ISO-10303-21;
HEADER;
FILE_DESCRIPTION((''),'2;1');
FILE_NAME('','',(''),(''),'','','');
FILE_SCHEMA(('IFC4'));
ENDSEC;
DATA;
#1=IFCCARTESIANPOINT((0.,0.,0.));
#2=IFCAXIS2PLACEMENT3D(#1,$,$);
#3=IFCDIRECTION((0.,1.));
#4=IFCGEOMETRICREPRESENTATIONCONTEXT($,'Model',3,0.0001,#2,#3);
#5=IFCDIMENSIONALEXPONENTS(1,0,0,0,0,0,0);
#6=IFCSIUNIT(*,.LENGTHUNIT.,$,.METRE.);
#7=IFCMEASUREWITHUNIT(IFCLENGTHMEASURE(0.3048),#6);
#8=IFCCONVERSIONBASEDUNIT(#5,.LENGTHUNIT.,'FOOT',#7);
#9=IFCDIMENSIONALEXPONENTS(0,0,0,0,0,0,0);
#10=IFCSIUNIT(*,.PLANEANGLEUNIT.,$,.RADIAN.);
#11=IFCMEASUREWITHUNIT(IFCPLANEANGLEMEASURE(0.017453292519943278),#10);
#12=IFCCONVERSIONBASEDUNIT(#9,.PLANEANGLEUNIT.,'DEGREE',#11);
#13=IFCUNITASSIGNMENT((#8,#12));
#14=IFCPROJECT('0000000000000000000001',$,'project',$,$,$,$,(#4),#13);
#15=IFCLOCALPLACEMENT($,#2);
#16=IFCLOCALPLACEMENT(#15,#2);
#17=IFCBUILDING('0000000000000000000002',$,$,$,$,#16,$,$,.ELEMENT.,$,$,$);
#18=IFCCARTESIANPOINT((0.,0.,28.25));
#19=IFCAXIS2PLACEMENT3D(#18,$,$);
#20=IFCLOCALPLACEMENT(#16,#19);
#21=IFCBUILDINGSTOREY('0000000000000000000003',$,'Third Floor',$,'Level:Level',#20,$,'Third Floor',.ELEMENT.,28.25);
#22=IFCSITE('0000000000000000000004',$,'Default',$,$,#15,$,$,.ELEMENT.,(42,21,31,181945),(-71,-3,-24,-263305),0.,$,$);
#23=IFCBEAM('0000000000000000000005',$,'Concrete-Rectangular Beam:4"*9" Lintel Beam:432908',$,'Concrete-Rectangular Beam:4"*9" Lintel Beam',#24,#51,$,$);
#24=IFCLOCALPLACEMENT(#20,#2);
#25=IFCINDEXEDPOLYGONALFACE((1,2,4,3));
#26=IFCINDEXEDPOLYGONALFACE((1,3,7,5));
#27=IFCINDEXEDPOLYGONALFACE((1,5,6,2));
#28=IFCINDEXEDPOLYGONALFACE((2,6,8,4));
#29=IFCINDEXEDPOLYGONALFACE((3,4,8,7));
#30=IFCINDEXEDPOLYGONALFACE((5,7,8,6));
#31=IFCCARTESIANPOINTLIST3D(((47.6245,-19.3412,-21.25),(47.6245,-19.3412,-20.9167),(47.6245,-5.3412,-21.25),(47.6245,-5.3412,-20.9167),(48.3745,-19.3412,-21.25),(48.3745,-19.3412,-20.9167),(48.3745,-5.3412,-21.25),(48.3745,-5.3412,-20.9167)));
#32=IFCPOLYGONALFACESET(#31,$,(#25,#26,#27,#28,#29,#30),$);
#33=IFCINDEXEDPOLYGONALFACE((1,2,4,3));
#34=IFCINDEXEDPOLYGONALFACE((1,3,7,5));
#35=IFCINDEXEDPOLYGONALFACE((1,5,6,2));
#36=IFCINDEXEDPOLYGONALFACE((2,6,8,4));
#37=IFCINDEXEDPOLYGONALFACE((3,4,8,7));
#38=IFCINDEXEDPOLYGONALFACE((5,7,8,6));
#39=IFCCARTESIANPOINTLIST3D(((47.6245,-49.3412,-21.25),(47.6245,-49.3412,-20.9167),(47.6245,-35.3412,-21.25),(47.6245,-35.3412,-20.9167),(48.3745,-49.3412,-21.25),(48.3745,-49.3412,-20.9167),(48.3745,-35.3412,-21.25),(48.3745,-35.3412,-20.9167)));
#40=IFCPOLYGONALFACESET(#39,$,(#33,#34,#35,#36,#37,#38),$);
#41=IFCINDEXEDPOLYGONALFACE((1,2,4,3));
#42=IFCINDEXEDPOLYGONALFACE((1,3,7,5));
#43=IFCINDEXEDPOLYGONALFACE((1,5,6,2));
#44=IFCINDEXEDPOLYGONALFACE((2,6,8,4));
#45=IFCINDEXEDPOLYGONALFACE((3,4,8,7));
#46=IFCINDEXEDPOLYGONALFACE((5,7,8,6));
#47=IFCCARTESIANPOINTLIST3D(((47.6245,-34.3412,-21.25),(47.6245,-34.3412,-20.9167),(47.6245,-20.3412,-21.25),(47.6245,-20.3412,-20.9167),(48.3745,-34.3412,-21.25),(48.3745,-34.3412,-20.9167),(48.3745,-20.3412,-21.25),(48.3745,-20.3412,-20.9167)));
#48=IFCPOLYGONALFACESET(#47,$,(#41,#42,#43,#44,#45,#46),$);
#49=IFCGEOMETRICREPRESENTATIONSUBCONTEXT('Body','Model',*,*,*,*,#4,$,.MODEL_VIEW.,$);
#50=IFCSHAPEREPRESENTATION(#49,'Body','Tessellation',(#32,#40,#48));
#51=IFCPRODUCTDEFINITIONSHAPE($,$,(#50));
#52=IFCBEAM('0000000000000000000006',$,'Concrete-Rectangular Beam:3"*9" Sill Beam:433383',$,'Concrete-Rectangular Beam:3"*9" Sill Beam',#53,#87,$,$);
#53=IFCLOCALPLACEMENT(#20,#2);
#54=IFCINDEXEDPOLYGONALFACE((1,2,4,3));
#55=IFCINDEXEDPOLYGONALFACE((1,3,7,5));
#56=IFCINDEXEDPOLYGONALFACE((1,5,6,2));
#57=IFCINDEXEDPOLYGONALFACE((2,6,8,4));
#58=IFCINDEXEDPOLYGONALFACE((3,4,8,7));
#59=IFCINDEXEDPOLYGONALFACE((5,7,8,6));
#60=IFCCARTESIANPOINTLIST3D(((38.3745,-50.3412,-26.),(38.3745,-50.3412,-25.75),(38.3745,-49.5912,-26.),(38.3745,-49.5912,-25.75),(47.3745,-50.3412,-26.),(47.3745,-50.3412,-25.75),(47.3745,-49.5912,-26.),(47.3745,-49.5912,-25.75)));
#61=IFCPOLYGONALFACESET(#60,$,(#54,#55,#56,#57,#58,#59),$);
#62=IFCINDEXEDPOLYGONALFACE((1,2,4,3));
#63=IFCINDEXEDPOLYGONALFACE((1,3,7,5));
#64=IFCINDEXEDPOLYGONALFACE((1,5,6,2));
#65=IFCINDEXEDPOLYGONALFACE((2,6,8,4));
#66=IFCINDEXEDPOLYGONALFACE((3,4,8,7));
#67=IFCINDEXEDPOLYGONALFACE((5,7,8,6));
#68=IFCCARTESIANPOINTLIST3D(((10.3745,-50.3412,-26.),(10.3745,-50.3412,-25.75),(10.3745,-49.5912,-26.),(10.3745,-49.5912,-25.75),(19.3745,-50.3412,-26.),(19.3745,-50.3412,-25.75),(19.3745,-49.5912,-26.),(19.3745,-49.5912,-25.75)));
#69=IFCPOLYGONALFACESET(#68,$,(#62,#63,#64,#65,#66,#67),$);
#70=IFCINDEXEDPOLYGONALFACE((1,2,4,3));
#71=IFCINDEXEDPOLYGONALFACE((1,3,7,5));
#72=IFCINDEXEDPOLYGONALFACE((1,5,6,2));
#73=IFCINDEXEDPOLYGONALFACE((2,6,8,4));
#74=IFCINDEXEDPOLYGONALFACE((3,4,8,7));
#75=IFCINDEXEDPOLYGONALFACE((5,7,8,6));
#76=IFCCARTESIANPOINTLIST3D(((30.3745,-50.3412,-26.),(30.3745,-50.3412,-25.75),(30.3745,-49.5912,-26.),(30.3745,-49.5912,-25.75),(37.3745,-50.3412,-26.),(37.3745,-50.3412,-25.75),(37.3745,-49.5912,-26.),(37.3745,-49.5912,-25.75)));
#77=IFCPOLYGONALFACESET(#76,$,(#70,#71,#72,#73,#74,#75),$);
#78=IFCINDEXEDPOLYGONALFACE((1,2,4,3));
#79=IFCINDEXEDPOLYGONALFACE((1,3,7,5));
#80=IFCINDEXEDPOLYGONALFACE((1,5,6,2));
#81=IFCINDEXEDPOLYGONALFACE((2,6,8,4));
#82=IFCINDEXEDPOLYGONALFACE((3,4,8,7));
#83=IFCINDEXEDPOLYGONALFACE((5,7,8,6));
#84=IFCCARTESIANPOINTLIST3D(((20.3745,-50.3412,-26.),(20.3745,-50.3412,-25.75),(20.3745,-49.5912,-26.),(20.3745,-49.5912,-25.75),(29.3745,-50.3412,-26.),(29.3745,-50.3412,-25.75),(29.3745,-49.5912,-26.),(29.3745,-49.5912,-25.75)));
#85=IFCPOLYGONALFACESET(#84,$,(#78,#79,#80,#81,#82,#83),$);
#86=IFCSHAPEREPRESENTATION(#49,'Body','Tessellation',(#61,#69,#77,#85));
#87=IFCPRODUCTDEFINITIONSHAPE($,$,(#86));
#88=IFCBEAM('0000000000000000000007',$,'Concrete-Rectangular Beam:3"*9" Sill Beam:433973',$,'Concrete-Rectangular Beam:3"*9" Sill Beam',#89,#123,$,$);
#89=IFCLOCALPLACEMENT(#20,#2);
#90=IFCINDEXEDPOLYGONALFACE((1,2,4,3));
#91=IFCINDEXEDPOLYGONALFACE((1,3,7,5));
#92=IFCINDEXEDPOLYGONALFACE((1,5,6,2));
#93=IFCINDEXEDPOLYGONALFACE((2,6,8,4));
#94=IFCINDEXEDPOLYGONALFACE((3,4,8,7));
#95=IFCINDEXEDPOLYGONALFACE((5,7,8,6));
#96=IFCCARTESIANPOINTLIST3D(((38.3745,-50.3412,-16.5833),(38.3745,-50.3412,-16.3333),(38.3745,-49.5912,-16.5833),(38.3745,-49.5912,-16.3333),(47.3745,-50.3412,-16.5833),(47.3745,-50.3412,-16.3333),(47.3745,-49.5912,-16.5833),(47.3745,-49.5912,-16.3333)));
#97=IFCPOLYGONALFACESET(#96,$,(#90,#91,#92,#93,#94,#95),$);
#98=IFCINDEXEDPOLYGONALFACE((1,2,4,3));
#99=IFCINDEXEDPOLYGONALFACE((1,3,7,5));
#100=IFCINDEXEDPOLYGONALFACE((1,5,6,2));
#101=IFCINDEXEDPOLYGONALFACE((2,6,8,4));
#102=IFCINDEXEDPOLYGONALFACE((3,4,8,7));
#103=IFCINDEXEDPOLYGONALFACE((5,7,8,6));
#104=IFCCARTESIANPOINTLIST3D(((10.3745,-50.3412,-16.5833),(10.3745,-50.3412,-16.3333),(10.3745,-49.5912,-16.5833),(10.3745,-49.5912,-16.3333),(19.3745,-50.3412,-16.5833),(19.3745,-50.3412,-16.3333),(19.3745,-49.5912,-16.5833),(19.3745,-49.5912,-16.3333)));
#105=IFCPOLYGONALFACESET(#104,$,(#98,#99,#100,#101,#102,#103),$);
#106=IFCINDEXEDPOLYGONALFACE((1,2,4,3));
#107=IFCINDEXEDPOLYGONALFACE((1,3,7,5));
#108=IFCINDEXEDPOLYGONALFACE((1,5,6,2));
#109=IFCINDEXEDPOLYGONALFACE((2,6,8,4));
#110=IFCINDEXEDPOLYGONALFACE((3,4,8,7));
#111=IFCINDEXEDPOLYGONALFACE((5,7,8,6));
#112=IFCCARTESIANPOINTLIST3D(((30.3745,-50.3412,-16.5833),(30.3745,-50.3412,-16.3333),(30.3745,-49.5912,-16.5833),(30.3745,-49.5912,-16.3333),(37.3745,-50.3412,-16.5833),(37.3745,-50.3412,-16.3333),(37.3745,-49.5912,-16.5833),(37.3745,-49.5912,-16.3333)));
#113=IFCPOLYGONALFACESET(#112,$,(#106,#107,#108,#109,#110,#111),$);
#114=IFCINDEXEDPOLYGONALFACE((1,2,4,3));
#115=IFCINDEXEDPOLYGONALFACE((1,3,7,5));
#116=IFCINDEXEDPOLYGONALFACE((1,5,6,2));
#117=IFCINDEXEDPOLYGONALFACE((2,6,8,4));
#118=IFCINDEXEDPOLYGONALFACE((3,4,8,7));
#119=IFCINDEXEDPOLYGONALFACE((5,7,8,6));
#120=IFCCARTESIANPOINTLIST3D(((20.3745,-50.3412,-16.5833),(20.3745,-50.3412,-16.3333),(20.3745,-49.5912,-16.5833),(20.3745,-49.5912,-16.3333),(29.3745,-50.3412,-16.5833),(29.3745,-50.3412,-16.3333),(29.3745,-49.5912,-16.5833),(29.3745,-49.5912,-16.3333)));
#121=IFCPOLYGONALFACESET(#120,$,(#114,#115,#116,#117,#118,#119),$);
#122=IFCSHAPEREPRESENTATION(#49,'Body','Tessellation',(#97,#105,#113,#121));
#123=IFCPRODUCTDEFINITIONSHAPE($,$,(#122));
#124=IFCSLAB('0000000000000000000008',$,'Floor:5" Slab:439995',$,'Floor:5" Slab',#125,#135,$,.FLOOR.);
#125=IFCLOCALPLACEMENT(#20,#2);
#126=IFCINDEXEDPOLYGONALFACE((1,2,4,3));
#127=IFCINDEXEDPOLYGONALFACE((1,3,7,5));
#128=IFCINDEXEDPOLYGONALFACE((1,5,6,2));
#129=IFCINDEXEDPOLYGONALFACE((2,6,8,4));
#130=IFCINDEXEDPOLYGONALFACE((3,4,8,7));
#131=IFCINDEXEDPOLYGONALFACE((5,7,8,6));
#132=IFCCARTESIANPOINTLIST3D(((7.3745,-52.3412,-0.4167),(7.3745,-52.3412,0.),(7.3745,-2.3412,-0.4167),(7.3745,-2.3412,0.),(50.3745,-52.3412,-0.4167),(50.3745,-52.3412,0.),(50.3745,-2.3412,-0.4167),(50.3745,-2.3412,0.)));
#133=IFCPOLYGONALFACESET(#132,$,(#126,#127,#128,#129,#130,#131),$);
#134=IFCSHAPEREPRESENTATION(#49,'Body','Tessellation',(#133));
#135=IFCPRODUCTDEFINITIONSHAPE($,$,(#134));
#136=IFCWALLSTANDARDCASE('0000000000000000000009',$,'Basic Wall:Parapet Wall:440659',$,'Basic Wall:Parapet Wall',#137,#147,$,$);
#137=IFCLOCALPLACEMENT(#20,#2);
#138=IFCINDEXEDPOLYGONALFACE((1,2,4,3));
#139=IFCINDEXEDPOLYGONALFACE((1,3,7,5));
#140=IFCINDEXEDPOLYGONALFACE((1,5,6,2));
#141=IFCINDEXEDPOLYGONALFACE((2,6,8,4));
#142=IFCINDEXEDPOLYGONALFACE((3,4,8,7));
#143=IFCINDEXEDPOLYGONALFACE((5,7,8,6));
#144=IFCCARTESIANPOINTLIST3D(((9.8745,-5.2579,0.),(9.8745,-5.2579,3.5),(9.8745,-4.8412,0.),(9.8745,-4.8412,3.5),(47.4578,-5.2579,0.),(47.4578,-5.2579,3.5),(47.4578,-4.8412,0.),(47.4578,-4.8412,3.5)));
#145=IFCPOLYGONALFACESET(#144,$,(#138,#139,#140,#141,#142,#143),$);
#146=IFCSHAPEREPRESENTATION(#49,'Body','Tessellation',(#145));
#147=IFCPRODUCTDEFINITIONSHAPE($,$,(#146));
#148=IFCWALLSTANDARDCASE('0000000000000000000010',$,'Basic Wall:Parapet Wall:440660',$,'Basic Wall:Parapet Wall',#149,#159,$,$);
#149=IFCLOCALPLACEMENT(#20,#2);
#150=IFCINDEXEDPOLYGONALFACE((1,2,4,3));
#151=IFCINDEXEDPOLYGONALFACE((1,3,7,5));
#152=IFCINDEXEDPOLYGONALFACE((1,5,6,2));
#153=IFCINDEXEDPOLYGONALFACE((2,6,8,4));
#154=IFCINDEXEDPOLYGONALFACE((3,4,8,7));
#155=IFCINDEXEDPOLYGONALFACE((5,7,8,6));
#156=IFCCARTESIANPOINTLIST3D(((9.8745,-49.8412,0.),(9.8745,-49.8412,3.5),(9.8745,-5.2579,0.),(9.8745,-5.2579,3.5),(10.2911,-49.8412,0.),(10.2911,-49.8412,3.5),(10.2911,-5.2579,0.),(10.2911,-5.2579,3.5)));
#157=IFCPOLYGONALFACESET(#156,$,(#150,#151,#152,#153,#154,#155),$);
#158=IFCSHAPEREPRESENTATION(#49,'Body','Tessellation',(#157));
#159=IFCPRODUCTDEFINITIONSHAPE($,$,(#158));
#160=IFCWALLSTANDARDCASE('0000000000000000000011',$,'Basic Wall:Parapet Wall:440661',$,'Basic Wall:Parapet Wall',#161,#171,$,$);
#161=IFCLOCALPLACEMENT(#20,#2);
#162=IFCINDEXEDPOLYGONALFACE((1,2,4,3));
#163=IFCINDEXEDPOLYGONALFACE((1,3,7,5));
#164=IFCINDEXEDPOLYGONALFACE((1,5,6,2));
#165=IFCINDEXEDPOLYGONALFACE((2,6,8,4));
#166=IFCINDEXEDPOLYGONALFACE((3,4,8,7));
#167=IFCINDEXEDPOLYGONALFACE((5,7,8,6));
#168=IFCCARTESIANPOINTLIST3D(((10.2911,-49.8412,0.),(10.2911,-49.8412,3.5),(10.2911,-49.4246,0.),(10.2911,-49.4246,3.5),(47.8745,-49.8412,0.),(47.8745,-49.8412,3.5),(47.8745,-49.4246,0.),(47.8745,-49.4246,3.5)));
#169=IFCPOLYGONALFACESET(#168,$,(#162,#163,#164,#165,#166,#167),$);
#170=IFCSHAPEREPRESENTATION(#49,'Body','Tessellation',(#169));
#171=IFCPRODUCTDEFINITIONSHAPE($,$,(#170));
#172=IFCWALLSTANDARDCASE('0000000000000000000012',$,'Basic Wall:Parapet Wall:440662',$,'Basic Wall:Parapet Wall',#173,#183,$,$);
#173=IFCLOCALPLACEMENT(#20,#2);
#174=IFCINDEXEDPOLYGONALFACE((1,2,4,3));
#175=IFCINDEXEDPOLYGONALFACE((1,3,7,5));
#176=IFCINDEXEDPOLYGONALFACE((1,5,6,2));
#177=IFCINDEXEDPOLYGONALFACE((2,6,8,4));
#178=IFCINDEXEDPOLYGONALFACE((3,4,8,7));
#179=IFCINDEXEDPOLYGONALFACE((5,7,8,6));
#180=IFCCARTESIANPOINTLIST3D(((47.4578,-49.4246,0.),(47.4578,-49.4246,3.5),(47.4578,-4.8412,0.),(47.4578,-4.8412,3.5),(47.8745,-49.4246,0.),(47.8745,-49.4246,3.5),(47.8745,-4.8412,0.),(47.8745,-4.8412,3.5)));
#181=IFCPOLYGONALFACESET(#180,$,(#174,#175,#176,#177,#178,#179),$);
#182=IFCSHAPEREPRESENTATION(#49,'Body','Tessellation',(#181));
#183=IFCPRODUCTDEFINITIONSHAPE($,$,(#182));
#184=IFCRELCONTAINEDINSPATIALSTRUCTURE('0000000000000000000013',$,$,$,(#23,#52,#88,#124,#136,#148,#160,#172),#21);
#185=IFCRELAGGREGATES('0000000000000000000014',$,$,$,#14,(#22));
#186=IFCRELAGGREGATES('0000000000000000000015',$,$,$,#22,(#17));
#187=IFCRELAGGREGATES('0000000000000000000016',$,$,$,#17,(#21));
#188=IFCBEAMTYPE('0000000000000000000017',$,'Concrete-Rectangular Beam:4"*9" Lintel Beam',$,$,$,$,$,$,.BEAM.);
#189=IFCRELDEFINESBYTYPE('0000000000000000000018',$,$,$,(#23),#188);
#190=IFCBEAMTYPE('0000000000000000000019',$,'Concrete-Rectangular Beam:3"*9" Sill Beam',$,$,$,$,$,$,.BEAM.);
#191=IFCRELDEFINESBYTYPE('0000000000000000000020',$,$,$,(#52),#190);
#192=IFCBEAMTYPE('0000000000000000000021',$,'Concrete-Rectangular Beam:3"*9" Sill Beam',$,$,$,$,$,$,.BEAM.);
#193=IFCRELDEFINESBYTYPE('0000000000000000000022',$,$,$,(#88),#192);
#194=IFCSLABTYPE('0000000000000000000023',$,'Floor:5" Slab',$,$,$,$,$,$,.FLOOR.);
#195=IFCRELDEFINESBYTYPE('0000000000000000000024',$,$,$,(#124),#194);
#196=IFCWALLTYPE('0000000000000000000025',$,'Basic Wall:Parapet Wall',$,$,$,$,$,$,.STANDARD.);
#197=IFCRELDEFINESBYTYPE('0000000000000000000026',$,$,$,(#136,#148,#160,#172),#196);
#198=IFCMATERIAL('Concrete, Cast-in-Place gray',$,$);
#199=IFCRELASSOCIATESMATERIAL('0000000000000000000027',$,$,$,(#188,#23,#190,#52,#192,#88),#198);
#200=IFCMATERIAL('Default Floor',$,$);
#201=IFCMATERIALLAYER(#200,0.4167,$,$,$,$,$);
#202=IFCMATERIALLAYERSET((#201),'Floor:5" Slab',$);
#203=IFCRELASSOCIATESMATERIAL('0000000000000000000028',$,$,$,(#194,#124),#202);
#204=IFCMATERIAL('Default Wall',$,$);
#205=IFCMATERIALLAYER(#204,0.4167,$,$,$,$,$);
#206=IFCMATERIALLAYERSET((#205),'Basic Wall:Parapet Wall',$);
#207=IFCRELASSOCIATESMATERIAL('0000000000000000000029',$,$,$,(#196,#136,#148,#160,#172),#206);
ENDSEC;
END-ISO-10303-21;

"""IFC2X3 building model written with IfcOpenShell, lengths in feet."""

from ifc_helpers import new_model, entity, si_unit, converted_unit, direction, frame, frame_2d, origin, origin_2d_with_axis, place, context, subcontext, project, spatial, rectangle, extrude, source, transform, mapped, material, layer, layer_set, layer_usage, type_object, type_shapes, element, save


model = new_model("IFC2X3")

# Units and contexts
model_context = context("Model", 3, precision=0.0001, world=origin(), true_north=direction((0.0, 1.0)))
body_context = subcontext(model_context, "Body", "Model", "MODEL_VIEW")
ifc_project = project(units=[converted_unit("LENGTHUNIT", "FOOT", entity("IfcLengthMeasure", 0.3048), si_unit("LENGTHUNIT", "METRE"), dimensions=[1, 0, 0, 0, 0, 0, 0]), converted_unit("PLANEANGLEUNIT", "DEGREE", entity("IfcPlaneAngleMeasure", 0.017453292519943278), si_unit("PLANEANGLEUNIT", "RADIAN"), dimensions=[0, 0, 0, 0, 0, 0, 0])], contexts=[model_context])

# Site, building, storey
site_placement = place(None, origin())
site = spatial("IfcSite", under=ifc_project, at=site_placement, Name="Default", CompositionType="ELEMENT", RefLatitude=(42, 21, 31, 181945), RefLongitude=(-71, -3, -24, -263305), RefElevation=0.0)
building_placement = place(site_placement, origin())
building = spatial("IfcBuilding", under=site, at=building_placement, CompositionType="ELEMENT")
storey_placement = place(building_placement, frame((0.0, 0.0, 28.25)))
storey = spatial("IfcBuildingStorey", under=building, at=storey_placement, Name="Third Floor", ObjectType="Level:Level", LongName="Third Floor", CompositionType="ELEMENT", Elevation=28.25)

# Beams
ifc_material_1 = material(Name="Concrete, Cast-in-Place gray")
beam_type_1 = type_object("IfcBeamType", Name="Concrete-Rectangular Beam:4\"*9\" Lintel Beam", PredefinedType="BEAM", material=ifc_material_1)
shared_shape_1 = source(origin(), body_context, "Body", "SweptSolid", [
    extrude(rectangle(XDim=0.3333, YDim=0.75, at=frame_2d((0.0, 0.0), x_axis=(0.0, 1.0))), frame((47.9995, -19.3412, 7.1667), z_axis=(0.0, 1.0, 0.0), x_axis=(-1.0, 0.0, 0.0)), (0.0, 0.0, 1.0), 14.0),
    extrude(rectangle(XDim=0.3333, YDim=0.75, at=frame_2d((0.0, 0.0), x_axis=(0.0, 1.0))), frame((47.9995, -49.3412, 7.1667), z_axis=(0.0, 1.0, 0.0), x_axis=(-1.0, 0.0, 0.0)), (0.0, 0.0, 1.0), 14.0),
    extrude(rectangle(XDim=0.3333, YDim=0.75, at=frame_2d((0.0, 0.0), x_axis=(0.0, 1.0))), frame((47.9995, -34.3412, 7.1667), z_axis=(0.0, 1.0, 0.0), x_axis=(-1.0, 0.0, 0.0)), (0.0, 0.0, 1.0), 14.0),
])
type_shapes(beam_type_1, [shared_shape_1])
beam_1_placement = place(storey_placement, frame((0.0, 0.0, -28.25)))
element("IfcBeam", 1, at=beam_1_placement, inside=storey, type_object=beam_type_1, material=ifc_material_1, Name="Concrete-Rectangular Beam:4\"*9\" Lintel Beam:432908", ObjectType="Concrete-Rectangular Beam:4\"*9\" Lintel Beam", context=body_context, shape_type="MappedRepresentation", body=[
    mapped(shared_shape_1, transform((0.0, 0.0, 0.0), scale=1.0)),
])
beam_type_2 = type_object("IfcBeamType", Name="Concrete-Rectangular Beam:3\"*9\" Sill Beam", PredefinedType="BEAM", material=ifc_material_1)
shared_shape_2 = source(origin(), body_context, "Body", "SweptSolid", [
    extrude(rectangle(XDim=0.25, YDim=0.75, at=frame_2d((0.0, 0.0), x_axis=(1.0, 0.0))), frame((38.3745, -49.9662, 2.375), z_axis=(1.0, 0.0, 0.0), x_axis=(0.0, 0.0, -1.0)), (0.0, 0.0, 1.0), 9.0),
    extrude(rectangle(XDim=0.25, YDim=0.75, at=frame_2d((0.0, 0.0), x_axis=(1.0, 0.0))), frame((10.3745, -49.9662, 2.375), z_axis=(1.0, 0.0, 0.0), x_axis=(0.0, 0.0, -1.0)), (0.0, 0.0, 1.0), 9.0),
    extrude(rectangle(XDim=0.25, YDim=0.75, at=frame_2d((0.0, 0.0), x_axis=(1.0, 0.0))), frame((30.3745, -49.9662, 2.375), z_axis=(1.0, 0.0, 0.0), x_axis=(0.0, 0.0, -1.0)), (0.0, 0.0, 1.0), 7.0),
    extrude(rectangle(XDim=0.25, YDim=0.75, at=frame_2d((0.0, 0.0), x_axis=(1.0, 0.0))), frame((20.3745, -49.9662, 2.375), z_axis=(1.0, 0.0, 0.0), x_axis=(0.0, 0.0, -1.0)), (0.0, 0.0, 1.0), 9.0),
])
type_shapes(beam_type_2, [shared_shape_2])
beam_2_placement = place(storey_placement, frame((0.0, 0.0, -28.25)))
element("IfcBeam", 2, at=beam_2_placement, inside=storey, type_object=beam_type_2, material=ifc_material_1, Name="Concrete-Rectangular Beam:3\"*9\" Sill Beam:433383", ObjectType="Concrete-Rectangular Beam:3\"*9\" Sill Beam", context=body_context, shape_type="MappedRepresentation", body=[
    mapped(shared_shape_2, transform((0.0, 0.0, 0.0), scale=1.0)),
])
beam_type_3 = type_object("IfcBeamType", Name="Concrete-Rectangular Beam:3\"*9\" Sill Beam", PredefinedType="BEAM", material=ifc_material_1)
shared_shape_3 = source(origin(), body_context, "Body", "SweptSolid", [
    extrude(rectangle(XDim=0.25, YDim=0.75, at=frame_2d((0.0, 0.0), x_axis=(1.0, 0.0))), frame((38.3745, -49.9662, 11.7917), z_axis=(1.0, 0.0, 0.0), x_axis=(0.0, 0.0, -1.0)), (0.0, 0.0, 1.0), 9.0),
    extrude(rectangle(XDim=0.25, YDim=0.75, at=frame_2d((0.0, 0.0), x_axis=(1.0, 0.0))), frame((10.3745, -49.9662, 11.7917), z_axis=(1.0, 0.0, 0.0), x_axis=(0.0, 0.0, -1.0)), (0.0, 0.0, 1.0), 9.0),
    extrude(rectangle(XDim=0.25, YDim=0.75, at=origin_2d_with_axis()), frame((30.3745, -49.9662, 11.7917), z_axis=(1.0, 0.0, 0.0), x_axis=(0.0, 0.0, -1.0)), (0.0, 0.0, 1.0), 7.0),
    extrude(rectangle(XDim=0.25, YDim=0.75, at=origin_2d_with_axis()), frame((20.3745, -49.9662, 11.7917), z_axis=(1.0, 0.0, 0.0), x_axis=(0.0, 0.0, -1.0)), (0.0, 0.0, 1.0), 9.0),
])
type_shapes(beam_type_3, [shared_shape_3])
beam_3_placement = place(storey_placement, frame((0.0, 0.0, -28.25)))
element("IfcBeam", 3, at=beam_3_placement, inside=storey, type_object=beam_type_3, material=ifc_material_1, Name="Concrete-Rectangular Beam:3\"*9\" Sill Beam:433973", ObjectType="Concrete-Rectangular Beam:3\"*9\" Sill Beam", context=body_context, shape_type="MappedRepresentation", body=[
    mapped(shared_shape_3, transform((0.0, 0.0, 0.0), scale=1.0)),
])

# Slab
ifc_material_2 = material(Name="Default Floor")
ifc_layer_1 = layer(ifc_material_2, 0.4167)
ifc_layer_set_1 = layer_set([ifc_layer_1], Name="Floor:5\" Slab")
ifc_layer_usage_1 = layer_usage(ifc_layer_set_1, "AXIS3", "POSITIVE", 0.0)
slab_type = type_object("IfcSlabType", Name="Floor:5\" Slab", PredefinedType="FLOOR", material=ifc_layer_set_1)
slab_placement = place(storey_placement, origin())
element("IfcSlab", 4, at=slab_placement, inside=storey, type_object=slab_type, material=ifc_layer_usage_1, Name="Floor:5\" Slab:439995", ObjectType="Floor:5\" Slab", PredefinedType="FLOOR", context=body_context, shape_type="SweptSolid", body=[
    extrude(rectangle(XDim=50.0, YDim=43.0, at=origin_2d_with_axis()), frame((28.8745, -27.3412, 0.0), z_axis=(0.0, 0.0, -1.0), x_axis=(0.0, 1.0, 0.0)), (0.0, 0.0, 1.0), 0.4167),
])

# Walls
ifc_material_3 = material(Name="Default Wall")
ifc_layer_2 = layer(ifc_material_3, 0.4167)
ifc_layer_set_2 = layer_set([ifc_layer_2], Name="Basic Wall:Parapet Wall")
ifc_layer_usage_2 = layer_usage(ifc_layer_set_2, "AXIS2", "NEGATIVE", 0.2083)
wall_type = type_object("IfcWallType", Name="Basic Wall:Parapet Wall", PredefinedType="STANDARD", material=ifc_layer_set_2)
wall_1_placement = place(storey_placement, frame((9.8745, -5.0496, 0.0)))
element("IfcWallStandardCase", 5, at=wall_1_placement, inside=storey, type_object=wall_type, material=ifc_layer_usage_2, Name="Basic Wall:Parapet Wall:440659", ObjectType="Basic Wall:Parapet Wall", context=body_context, shape_type="SweptSolid", body=[
    extrude(rectangle(XDim=37.5833, YDim=0.4167, at=frame_2d((18.7917, 0.0), x_axis=(-1.0, 0.0))), origin(), (0.0, 0.0, 1.0), 3.5),
])
wall_2_placement = place(storey_placement, frame((10.0828, -49.8412, 0.0), z_axis=(0.0, 0.0, 1.0), x_axis=(0.0, 1.0, 0.0)))
element("IfcWallStandardCase", 6, at=wall_2_placement, inside=storey, type_object=wall_type, material=ifc_layer_usage_2, Name="Basic Wall:Parapet Wall:440660", ObjectType="Basic Wall:Parapet Wall", context=body_context, shape_type="SweptSolid", body=[
    extrude(rectangle(XDim=44.5833, YDim=0.4167, at=frame_2d((22.2917, 0.0), x_axis=(-1.0, 0.0))), origin(), (0.0, 0.0, 1.0), 3.5),
])
wall_3_placement = place(storey_placement, frame((47.8745, -49.6329, 0.0), z_axis=(0.0, 0.0, 1.0), x_axis=(-1.0, 0.0, 0.0)))
element("IfcWallStandardCase", 7, at=wall_3_placement, inside=storey, type_object=wall_type, material=ifc_layer_usage_2, Name="Basic Wall:Parapet Wall:440661", ObjectType="Basic Wall:Parapet Wall", context=body_context, shape_type="SweptSolid", body=[
    extrude(rectangle(XDim=37.5833, YDim=0.4167, at=frame_2d((18.7917, 0.0), x_axis=(-1.0, 0.0))), origin(), (0.0, 0.0, 1.0), 3.5),
])
wall_4_placement = place(storey_placement, frame((47.6661, -4.8412, 0.0), z_axis=(0.0, 0.0, 1.0), x_axis=(0.0, -1.0, 0.0)))
element("IfcWallStandardCase", 8, at=wall_4_placement, inside=storey, type_object=wall_type, material=ifc_layer_usage_2, Name="Basic Wall:Parapet Wall:440662", ObjectType="Basic Wall:Parapet Wall", context=body_context, shape_type="SweptSolid", body=[
    extrude(rectangle(XDim=44.5833, YDim=0.4167, at=frame_2d((22.2917, 0.0), x_axis=(-1.0, 0.0))), origin(), (0.0, 0.0, 1.0), 3.5),
])

save(model, "model.ifc")
